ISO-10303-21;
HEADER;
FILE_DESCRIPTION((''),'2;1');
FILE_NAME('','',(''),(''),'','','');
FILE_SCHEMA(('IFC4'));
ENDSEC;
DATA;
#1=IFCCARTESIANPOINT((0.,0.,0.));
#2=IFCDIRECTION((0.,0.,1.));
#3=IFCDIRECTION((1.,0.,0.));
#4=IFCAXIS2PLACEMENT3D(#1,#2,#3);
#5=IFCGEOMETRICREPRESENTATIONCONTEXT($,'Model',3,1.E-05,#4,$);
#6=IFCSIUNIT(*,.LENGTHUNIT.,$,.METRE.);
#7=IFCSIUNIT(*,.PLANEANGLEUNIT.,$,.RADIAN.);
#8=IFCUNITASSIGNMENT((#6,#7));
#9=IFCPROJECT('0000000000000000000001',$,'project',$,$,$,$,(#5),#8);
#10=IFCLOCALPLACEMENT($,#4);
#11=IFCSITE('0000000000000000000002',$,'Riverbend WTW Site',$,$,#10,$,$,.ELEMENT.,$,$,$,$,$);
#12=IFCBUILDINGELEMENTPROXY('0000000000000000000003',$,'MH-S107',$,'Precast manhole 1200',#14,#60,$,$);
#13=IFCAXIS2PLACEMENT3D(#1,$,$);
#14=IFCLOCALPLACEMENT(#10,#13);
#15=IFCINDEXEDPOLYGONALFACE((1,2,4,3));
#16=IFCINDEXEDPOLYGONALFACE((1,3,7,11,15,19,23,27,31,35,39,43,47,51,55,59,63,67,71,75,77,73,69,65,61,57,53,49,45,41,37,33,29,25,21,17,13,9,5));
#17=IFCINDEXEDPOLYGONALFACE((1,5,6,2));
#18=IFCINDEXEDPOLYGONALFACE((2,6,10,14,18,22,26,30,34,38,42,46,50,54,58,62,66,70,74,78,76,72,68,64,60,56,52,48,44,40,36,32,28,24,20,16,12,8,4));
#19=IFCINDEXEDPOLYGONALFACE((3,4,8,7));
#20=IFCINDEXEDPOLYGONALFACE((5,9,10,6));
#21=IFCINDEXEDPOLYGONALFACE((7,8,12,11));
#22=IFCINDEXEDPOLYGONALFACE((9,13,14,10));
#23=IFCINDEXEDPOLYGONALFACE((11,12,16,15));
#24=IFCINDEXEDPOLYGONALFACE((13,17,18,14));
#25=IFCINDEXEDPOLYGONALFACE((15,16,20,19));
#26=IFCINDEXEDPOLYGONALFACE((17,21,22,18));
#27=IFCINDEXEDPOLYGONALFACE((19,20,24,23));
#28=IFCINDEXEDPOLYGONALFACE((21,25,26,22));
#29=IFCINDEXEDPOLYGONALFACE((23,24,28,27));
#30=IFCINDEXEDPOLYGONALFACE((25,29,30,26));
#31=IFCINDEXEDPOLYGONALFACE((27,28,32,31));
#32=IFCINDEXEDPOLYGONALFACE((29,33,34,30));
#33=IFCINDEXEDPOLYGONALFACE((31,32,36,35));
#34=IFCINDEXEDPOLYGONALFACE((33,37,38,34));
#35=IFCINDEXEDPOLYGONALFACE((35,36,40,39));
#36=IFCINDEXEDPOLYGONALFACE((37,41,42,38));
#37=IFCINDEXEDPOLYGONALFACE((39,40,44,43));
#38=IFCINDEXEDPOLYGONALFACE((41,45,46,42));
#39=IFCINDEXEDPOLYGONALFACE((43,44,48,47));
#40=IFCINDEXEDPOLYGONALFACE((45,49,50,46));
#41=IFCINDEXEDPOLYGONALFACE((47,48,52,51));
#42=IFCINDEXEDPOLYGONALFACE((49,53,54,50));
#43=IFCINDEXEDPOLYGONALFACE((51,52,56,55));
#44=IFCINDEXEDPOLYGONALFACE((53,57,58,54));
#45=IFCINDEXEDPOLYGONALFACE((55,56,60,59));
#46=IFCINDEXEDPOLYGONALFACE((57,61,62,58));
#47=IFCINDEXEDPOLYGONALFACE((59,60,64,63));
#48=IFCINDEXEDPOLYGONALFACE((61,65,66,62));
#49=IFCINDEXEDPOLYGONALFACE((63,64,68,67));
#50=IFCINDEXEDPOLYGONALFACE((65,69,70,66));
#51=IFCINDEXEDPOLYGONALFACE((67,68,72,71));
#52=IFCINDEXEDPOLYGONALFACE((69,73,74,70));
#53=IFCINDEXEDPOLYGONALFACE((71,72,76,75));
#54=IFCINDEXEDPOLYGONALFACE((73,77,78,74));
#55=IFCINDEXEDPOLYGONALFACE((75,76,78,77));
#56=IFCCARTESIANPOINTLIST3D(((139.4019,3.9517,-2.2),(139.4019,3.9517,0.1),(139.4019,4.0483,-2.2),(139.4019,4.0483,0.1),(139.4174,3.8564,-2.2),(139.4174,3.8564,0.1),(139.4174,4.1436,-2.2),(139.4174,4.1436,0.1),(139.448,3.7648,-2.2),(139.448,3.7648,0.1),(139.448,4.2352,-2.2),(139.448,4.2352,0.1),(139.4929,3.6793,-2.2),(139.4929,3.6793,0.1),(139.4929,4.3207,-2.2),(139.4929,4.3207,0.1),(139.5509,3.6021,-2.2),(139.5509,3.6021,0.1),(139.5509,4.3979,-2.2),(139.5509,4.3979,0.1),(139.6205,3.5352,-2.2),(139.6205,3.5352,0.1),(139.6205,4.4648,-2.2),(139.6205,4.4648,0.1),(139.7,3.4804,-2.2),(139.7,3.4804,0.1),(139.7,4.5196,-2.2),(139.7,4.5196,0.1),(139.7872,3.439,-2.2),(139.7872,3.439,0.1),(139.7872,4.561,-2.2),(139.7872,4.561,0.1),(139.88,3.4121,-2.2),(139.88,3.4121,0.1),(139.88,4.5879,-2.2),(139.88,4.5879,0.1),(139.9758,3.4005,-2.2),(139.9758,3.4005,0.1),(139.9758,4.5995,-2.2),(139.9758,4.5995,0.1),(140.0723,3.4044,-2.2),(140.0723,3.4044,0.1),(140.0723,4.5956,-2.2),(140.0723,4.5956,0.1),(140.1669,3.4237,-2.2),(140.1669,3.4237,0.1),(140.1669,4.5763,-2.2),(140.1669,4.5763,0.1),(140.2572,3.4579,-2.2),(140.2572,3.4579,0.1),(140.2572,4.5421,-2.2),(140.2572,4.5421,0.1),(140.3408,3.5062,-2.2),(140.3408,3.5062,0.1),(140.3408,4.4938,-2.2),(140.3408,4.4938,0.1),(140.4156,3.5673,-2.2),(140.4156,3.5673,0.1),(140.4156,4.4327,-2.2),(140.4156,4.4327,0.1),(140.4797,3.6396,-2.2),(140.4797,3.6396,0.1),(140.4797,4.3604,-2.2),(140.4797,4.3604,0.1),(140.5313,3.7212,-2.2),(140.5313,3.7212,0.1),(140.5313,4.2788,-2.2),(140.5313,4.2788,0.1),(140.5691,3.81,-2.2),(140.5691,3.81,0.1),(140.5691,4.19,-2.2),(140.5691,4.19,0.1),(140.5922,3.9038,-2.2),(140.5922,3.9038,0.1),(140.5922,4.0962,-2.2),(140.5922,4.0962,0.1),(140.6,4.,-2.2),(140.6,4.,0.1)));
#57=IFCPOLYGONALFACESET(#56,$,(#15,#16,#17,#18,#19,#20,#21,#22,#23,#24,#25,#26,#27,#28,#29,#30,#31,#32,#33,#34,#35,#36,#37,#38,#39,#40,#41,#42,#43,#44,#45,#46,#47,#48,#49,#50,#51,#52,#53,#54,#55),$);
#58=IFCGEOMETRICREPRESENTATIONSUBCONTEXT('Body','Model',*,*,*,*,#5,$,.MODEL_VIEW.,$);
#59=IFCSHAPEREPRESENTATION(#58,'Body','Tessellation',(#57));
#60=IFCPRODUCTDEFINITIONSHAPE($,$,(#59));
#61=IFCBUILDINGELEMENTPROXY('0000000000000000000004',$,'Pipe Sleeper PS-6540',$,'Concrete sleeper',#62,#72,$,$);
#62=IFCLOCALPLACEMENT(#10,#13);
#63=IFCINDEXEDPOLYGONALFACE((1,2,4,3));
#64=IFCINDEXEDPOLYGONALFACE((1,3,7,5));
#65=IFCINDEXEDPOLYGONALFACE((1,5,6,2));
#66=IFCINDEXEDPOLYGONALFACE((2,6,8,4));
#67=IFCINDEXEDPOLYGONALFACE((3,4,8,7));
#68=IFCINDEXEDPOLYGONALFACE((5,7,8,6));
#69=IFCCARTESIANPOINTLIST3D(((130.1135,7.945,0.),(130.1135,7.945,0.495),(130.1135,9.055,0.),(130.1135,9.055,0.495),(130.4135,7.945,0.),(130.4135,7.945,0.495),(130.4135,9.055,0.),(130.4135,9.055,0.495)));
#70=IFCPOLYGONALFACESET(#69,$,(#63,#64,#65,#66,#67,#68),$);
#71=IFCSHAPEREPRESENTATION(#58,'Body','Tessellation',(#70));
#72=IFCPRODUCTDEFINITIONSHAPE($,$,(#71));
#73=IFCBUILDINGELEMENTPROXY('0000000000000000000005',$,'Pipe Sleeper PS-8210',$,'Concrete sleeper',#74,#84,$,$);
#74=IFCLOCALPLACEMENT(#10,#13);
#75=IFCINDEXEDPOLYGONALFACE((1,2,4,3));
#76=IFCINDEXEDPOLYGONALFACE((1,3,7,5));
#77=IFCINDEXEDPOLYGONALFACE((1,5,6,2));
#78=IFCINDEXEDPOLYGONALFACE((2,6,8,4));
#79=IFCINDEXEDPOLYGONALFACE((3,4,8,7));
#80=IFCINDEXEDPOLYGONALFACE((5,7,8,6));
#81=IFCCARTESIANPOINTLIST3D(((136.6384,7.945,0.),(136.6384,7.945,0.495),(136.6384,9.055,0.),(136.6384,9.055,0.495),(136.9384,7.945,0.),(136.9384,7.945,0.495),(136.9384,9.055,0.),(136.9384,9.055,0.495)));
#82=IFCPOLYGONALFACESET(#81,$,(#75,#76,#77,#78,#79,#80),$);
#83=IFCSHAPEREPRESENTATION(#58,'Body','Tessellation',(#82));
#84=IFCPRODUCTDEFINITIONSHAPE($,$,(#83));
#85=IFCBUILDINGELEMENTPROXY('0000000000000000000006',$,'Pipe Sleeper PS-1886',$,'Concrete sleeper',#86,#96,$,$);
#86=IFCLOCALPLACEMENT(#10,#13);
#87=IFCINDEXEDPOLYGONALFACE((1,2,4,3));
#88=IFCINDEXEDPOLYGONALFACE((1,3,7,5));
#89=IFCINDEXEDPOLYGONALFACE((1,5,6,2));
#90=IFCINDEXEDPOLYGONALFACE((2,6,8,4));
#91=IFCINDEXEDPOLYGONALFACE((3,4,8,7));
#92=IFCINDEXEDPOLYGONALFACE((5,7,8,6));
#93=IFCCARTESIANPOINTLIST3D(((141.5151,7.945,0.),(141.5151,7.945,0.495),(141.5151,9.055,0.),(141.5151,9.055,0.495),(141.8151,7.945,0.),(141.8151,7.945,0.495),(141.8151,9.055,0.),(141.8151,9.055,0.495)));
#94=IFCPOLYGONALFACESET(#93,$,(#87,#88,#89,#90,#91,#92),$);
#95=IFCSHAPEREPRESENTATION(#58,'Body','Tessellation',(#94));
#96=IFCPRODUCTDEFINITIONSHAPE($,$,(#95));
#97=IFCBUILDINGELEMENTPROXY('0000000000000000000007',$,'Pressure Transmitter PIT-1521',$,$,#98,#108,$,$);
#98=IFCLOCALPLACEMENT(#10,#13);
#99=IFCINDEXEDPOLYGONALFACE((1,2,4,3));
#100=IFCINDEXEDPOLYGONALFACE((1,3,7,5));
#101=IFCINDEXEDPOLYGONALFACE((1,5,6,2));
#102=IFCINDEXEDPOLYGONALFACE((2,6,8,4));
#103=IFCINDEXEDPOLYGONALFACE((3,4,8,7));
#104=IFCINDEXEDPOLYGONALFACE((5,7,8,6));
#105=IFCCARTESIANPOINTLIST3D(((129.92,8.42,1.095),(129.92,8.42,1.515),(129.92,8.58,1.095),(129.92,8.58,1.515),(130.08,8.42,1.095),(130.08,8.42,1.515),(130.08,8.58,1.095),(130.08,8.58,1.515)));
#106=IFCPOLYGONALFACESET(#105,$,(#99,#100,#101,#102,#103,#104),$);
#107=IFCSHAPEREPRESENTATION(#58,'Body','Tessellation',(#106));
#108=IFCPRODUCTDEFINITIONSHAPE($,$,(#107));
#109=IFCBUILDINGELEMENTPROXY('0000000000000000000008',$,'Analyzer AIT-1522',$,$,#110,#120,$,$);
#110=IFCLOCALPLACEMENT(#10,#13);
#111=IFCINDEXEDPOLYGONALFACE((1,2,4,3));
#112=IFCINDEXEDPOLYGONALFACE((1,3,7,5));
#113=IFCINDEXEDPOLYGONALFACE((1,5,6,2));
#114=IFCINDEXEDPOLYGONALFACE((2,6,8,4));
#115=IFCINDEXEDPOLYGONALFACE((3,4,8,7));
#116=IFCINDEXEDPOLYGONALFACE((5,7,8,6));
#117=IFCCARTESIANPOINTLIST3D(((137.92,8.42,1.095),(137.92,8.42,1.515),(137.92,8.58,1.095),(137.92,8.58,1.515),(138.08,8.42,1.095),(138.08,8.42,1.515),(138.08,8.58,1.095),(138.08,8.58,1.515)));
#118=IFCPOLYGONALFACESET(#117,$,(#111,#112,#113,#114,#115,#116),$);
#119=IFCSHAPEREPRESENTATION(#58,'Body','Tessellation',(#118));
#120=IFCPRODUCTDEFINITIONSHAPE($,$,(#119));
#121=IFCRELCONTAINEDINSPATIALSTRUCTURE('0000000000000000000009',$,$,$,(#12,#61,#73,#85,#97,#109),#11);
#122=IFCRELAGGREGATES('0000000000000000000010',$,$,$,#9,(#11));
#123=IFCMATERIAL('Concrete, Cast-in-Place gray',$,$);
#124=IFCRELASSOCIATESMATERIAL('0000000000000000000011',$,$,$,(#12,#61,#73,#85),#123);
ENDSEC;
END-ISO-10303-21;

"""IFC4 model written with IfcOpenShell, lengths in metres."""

from ifc_helpers import new_model, si_unit, frame, origin_with_axes, origin_2d, place, context, subcontext, project, spatial, rectangle, circle, extrude, material, element, save


model = new_model("IFC4")

# Units and contexts
model_context = context("Model", 3, precision=1e-05, world=origin_with_axes())
body_context = subcontext(model_context, "Body", "Model", "MODEL_VIEW")
ifc_project = project(units=[si_unit("LENGTHUNIT", "METRE"), si_unit("PLANEANGLEUNIT", "RADIAN")], contexts=[model_context])

# Site
site_placement = place(None, origin_with_axes())
site = spatial("IfcSite", under=ifc_project, at=site_placement, Name="Riverbend WTW Site", CompositionType="ELEMENT")

# Building element proxies
ifc_material_1 = material(Name="Concrete, Cast-in-Place gray")
proxy_1_placement = place(None, frame((140.0, 4.0, -2.2), z_axis=(0.0, 0.0, 1.0), x_axis=(1.0, 0.0, 0.0)))
element("IfcBuildingElementProxy", 1, at=proxy_1_placement, inside=site, material=ifc_material_1, Name="MH-S107", ObjectType="Precast manhole 1200", context=body_context, shape_type="SweptSolid", body=[
    extrude(circle(Radius=0.6, at=origin_2d()), origin_with_axes(), (0.0, 0.0, 1.0), 2.3),
])
for number, where, z_axis, x_axis, name in (
    (2, (130.2635, 8.5, 0.2475), (0.0, 0.0, 1.0), (1.0, 0.0, 0.0), "Pipe Sleeper PS-6540"),
    (3, (136.7884, 8.5, 0.2475), (0.0, 0.0, 1.0), (1.0, 0.0, 0.0), "Pipe Sleeper PS-8210"),
    (4, (141.6651, 8.5, 0.2475), (0.0, 0.0, 1.0), (1.0, 0.0, 0.0), "Pipe Sleeper PS-1886"),
):
    element("IfcBuildingElementProxy", number, at=place(None, frame(where, z_axis=z_axis, x_axis=x_axis)), inside=site, material=ifc_material_1, Name=name, ObjectType="Concrete sleeper", context=body_context, shape_type="SweptSolid", body=[
        extrude(rectangle(XDim=0.3, YDim=1.11, at=origin_2d()), frame((0.0, 0.0, -0.2475), z_axis=(0.0, 0.0, 1.0), x_axis=(1.0, 0.0, 0.0)), (0.0, 0.0, 1.0), 0.495),
    ])
for number, where, z_axis, x_axis, name in (
    (5, (130.0, 8.5, 1.305), (0.0, 0.0, 1.0), (1.0, 0.0, 0.0), "Pressure Transmitter PIT-1521"),
    (6, (138.0, 8.5, 1.305), (0.0, 0.0, 1.0), (1.0, 0.0, 0.0), "Analyzer AIT-1522"),
):
    element("IfcBuildingElementProxy", number, at=place(None, frame(where, z_axis=z_axis, x_axis=x_axis)), inside=site, Name=name, context=body_context, shape_type="SweptSolid", body=[
        extrude(rectangle(XDim=0.16, YDim=0.16, at=origin_2d()), frame((0.0, 0.0, -0.21), z_axis=(0.0, 0.0, 1.0), x_axis=(1.0, 0.0, 0.0)), (0.0, 0.0, 1.0), 0.42),
    ])

save(model, "model.ifc")
